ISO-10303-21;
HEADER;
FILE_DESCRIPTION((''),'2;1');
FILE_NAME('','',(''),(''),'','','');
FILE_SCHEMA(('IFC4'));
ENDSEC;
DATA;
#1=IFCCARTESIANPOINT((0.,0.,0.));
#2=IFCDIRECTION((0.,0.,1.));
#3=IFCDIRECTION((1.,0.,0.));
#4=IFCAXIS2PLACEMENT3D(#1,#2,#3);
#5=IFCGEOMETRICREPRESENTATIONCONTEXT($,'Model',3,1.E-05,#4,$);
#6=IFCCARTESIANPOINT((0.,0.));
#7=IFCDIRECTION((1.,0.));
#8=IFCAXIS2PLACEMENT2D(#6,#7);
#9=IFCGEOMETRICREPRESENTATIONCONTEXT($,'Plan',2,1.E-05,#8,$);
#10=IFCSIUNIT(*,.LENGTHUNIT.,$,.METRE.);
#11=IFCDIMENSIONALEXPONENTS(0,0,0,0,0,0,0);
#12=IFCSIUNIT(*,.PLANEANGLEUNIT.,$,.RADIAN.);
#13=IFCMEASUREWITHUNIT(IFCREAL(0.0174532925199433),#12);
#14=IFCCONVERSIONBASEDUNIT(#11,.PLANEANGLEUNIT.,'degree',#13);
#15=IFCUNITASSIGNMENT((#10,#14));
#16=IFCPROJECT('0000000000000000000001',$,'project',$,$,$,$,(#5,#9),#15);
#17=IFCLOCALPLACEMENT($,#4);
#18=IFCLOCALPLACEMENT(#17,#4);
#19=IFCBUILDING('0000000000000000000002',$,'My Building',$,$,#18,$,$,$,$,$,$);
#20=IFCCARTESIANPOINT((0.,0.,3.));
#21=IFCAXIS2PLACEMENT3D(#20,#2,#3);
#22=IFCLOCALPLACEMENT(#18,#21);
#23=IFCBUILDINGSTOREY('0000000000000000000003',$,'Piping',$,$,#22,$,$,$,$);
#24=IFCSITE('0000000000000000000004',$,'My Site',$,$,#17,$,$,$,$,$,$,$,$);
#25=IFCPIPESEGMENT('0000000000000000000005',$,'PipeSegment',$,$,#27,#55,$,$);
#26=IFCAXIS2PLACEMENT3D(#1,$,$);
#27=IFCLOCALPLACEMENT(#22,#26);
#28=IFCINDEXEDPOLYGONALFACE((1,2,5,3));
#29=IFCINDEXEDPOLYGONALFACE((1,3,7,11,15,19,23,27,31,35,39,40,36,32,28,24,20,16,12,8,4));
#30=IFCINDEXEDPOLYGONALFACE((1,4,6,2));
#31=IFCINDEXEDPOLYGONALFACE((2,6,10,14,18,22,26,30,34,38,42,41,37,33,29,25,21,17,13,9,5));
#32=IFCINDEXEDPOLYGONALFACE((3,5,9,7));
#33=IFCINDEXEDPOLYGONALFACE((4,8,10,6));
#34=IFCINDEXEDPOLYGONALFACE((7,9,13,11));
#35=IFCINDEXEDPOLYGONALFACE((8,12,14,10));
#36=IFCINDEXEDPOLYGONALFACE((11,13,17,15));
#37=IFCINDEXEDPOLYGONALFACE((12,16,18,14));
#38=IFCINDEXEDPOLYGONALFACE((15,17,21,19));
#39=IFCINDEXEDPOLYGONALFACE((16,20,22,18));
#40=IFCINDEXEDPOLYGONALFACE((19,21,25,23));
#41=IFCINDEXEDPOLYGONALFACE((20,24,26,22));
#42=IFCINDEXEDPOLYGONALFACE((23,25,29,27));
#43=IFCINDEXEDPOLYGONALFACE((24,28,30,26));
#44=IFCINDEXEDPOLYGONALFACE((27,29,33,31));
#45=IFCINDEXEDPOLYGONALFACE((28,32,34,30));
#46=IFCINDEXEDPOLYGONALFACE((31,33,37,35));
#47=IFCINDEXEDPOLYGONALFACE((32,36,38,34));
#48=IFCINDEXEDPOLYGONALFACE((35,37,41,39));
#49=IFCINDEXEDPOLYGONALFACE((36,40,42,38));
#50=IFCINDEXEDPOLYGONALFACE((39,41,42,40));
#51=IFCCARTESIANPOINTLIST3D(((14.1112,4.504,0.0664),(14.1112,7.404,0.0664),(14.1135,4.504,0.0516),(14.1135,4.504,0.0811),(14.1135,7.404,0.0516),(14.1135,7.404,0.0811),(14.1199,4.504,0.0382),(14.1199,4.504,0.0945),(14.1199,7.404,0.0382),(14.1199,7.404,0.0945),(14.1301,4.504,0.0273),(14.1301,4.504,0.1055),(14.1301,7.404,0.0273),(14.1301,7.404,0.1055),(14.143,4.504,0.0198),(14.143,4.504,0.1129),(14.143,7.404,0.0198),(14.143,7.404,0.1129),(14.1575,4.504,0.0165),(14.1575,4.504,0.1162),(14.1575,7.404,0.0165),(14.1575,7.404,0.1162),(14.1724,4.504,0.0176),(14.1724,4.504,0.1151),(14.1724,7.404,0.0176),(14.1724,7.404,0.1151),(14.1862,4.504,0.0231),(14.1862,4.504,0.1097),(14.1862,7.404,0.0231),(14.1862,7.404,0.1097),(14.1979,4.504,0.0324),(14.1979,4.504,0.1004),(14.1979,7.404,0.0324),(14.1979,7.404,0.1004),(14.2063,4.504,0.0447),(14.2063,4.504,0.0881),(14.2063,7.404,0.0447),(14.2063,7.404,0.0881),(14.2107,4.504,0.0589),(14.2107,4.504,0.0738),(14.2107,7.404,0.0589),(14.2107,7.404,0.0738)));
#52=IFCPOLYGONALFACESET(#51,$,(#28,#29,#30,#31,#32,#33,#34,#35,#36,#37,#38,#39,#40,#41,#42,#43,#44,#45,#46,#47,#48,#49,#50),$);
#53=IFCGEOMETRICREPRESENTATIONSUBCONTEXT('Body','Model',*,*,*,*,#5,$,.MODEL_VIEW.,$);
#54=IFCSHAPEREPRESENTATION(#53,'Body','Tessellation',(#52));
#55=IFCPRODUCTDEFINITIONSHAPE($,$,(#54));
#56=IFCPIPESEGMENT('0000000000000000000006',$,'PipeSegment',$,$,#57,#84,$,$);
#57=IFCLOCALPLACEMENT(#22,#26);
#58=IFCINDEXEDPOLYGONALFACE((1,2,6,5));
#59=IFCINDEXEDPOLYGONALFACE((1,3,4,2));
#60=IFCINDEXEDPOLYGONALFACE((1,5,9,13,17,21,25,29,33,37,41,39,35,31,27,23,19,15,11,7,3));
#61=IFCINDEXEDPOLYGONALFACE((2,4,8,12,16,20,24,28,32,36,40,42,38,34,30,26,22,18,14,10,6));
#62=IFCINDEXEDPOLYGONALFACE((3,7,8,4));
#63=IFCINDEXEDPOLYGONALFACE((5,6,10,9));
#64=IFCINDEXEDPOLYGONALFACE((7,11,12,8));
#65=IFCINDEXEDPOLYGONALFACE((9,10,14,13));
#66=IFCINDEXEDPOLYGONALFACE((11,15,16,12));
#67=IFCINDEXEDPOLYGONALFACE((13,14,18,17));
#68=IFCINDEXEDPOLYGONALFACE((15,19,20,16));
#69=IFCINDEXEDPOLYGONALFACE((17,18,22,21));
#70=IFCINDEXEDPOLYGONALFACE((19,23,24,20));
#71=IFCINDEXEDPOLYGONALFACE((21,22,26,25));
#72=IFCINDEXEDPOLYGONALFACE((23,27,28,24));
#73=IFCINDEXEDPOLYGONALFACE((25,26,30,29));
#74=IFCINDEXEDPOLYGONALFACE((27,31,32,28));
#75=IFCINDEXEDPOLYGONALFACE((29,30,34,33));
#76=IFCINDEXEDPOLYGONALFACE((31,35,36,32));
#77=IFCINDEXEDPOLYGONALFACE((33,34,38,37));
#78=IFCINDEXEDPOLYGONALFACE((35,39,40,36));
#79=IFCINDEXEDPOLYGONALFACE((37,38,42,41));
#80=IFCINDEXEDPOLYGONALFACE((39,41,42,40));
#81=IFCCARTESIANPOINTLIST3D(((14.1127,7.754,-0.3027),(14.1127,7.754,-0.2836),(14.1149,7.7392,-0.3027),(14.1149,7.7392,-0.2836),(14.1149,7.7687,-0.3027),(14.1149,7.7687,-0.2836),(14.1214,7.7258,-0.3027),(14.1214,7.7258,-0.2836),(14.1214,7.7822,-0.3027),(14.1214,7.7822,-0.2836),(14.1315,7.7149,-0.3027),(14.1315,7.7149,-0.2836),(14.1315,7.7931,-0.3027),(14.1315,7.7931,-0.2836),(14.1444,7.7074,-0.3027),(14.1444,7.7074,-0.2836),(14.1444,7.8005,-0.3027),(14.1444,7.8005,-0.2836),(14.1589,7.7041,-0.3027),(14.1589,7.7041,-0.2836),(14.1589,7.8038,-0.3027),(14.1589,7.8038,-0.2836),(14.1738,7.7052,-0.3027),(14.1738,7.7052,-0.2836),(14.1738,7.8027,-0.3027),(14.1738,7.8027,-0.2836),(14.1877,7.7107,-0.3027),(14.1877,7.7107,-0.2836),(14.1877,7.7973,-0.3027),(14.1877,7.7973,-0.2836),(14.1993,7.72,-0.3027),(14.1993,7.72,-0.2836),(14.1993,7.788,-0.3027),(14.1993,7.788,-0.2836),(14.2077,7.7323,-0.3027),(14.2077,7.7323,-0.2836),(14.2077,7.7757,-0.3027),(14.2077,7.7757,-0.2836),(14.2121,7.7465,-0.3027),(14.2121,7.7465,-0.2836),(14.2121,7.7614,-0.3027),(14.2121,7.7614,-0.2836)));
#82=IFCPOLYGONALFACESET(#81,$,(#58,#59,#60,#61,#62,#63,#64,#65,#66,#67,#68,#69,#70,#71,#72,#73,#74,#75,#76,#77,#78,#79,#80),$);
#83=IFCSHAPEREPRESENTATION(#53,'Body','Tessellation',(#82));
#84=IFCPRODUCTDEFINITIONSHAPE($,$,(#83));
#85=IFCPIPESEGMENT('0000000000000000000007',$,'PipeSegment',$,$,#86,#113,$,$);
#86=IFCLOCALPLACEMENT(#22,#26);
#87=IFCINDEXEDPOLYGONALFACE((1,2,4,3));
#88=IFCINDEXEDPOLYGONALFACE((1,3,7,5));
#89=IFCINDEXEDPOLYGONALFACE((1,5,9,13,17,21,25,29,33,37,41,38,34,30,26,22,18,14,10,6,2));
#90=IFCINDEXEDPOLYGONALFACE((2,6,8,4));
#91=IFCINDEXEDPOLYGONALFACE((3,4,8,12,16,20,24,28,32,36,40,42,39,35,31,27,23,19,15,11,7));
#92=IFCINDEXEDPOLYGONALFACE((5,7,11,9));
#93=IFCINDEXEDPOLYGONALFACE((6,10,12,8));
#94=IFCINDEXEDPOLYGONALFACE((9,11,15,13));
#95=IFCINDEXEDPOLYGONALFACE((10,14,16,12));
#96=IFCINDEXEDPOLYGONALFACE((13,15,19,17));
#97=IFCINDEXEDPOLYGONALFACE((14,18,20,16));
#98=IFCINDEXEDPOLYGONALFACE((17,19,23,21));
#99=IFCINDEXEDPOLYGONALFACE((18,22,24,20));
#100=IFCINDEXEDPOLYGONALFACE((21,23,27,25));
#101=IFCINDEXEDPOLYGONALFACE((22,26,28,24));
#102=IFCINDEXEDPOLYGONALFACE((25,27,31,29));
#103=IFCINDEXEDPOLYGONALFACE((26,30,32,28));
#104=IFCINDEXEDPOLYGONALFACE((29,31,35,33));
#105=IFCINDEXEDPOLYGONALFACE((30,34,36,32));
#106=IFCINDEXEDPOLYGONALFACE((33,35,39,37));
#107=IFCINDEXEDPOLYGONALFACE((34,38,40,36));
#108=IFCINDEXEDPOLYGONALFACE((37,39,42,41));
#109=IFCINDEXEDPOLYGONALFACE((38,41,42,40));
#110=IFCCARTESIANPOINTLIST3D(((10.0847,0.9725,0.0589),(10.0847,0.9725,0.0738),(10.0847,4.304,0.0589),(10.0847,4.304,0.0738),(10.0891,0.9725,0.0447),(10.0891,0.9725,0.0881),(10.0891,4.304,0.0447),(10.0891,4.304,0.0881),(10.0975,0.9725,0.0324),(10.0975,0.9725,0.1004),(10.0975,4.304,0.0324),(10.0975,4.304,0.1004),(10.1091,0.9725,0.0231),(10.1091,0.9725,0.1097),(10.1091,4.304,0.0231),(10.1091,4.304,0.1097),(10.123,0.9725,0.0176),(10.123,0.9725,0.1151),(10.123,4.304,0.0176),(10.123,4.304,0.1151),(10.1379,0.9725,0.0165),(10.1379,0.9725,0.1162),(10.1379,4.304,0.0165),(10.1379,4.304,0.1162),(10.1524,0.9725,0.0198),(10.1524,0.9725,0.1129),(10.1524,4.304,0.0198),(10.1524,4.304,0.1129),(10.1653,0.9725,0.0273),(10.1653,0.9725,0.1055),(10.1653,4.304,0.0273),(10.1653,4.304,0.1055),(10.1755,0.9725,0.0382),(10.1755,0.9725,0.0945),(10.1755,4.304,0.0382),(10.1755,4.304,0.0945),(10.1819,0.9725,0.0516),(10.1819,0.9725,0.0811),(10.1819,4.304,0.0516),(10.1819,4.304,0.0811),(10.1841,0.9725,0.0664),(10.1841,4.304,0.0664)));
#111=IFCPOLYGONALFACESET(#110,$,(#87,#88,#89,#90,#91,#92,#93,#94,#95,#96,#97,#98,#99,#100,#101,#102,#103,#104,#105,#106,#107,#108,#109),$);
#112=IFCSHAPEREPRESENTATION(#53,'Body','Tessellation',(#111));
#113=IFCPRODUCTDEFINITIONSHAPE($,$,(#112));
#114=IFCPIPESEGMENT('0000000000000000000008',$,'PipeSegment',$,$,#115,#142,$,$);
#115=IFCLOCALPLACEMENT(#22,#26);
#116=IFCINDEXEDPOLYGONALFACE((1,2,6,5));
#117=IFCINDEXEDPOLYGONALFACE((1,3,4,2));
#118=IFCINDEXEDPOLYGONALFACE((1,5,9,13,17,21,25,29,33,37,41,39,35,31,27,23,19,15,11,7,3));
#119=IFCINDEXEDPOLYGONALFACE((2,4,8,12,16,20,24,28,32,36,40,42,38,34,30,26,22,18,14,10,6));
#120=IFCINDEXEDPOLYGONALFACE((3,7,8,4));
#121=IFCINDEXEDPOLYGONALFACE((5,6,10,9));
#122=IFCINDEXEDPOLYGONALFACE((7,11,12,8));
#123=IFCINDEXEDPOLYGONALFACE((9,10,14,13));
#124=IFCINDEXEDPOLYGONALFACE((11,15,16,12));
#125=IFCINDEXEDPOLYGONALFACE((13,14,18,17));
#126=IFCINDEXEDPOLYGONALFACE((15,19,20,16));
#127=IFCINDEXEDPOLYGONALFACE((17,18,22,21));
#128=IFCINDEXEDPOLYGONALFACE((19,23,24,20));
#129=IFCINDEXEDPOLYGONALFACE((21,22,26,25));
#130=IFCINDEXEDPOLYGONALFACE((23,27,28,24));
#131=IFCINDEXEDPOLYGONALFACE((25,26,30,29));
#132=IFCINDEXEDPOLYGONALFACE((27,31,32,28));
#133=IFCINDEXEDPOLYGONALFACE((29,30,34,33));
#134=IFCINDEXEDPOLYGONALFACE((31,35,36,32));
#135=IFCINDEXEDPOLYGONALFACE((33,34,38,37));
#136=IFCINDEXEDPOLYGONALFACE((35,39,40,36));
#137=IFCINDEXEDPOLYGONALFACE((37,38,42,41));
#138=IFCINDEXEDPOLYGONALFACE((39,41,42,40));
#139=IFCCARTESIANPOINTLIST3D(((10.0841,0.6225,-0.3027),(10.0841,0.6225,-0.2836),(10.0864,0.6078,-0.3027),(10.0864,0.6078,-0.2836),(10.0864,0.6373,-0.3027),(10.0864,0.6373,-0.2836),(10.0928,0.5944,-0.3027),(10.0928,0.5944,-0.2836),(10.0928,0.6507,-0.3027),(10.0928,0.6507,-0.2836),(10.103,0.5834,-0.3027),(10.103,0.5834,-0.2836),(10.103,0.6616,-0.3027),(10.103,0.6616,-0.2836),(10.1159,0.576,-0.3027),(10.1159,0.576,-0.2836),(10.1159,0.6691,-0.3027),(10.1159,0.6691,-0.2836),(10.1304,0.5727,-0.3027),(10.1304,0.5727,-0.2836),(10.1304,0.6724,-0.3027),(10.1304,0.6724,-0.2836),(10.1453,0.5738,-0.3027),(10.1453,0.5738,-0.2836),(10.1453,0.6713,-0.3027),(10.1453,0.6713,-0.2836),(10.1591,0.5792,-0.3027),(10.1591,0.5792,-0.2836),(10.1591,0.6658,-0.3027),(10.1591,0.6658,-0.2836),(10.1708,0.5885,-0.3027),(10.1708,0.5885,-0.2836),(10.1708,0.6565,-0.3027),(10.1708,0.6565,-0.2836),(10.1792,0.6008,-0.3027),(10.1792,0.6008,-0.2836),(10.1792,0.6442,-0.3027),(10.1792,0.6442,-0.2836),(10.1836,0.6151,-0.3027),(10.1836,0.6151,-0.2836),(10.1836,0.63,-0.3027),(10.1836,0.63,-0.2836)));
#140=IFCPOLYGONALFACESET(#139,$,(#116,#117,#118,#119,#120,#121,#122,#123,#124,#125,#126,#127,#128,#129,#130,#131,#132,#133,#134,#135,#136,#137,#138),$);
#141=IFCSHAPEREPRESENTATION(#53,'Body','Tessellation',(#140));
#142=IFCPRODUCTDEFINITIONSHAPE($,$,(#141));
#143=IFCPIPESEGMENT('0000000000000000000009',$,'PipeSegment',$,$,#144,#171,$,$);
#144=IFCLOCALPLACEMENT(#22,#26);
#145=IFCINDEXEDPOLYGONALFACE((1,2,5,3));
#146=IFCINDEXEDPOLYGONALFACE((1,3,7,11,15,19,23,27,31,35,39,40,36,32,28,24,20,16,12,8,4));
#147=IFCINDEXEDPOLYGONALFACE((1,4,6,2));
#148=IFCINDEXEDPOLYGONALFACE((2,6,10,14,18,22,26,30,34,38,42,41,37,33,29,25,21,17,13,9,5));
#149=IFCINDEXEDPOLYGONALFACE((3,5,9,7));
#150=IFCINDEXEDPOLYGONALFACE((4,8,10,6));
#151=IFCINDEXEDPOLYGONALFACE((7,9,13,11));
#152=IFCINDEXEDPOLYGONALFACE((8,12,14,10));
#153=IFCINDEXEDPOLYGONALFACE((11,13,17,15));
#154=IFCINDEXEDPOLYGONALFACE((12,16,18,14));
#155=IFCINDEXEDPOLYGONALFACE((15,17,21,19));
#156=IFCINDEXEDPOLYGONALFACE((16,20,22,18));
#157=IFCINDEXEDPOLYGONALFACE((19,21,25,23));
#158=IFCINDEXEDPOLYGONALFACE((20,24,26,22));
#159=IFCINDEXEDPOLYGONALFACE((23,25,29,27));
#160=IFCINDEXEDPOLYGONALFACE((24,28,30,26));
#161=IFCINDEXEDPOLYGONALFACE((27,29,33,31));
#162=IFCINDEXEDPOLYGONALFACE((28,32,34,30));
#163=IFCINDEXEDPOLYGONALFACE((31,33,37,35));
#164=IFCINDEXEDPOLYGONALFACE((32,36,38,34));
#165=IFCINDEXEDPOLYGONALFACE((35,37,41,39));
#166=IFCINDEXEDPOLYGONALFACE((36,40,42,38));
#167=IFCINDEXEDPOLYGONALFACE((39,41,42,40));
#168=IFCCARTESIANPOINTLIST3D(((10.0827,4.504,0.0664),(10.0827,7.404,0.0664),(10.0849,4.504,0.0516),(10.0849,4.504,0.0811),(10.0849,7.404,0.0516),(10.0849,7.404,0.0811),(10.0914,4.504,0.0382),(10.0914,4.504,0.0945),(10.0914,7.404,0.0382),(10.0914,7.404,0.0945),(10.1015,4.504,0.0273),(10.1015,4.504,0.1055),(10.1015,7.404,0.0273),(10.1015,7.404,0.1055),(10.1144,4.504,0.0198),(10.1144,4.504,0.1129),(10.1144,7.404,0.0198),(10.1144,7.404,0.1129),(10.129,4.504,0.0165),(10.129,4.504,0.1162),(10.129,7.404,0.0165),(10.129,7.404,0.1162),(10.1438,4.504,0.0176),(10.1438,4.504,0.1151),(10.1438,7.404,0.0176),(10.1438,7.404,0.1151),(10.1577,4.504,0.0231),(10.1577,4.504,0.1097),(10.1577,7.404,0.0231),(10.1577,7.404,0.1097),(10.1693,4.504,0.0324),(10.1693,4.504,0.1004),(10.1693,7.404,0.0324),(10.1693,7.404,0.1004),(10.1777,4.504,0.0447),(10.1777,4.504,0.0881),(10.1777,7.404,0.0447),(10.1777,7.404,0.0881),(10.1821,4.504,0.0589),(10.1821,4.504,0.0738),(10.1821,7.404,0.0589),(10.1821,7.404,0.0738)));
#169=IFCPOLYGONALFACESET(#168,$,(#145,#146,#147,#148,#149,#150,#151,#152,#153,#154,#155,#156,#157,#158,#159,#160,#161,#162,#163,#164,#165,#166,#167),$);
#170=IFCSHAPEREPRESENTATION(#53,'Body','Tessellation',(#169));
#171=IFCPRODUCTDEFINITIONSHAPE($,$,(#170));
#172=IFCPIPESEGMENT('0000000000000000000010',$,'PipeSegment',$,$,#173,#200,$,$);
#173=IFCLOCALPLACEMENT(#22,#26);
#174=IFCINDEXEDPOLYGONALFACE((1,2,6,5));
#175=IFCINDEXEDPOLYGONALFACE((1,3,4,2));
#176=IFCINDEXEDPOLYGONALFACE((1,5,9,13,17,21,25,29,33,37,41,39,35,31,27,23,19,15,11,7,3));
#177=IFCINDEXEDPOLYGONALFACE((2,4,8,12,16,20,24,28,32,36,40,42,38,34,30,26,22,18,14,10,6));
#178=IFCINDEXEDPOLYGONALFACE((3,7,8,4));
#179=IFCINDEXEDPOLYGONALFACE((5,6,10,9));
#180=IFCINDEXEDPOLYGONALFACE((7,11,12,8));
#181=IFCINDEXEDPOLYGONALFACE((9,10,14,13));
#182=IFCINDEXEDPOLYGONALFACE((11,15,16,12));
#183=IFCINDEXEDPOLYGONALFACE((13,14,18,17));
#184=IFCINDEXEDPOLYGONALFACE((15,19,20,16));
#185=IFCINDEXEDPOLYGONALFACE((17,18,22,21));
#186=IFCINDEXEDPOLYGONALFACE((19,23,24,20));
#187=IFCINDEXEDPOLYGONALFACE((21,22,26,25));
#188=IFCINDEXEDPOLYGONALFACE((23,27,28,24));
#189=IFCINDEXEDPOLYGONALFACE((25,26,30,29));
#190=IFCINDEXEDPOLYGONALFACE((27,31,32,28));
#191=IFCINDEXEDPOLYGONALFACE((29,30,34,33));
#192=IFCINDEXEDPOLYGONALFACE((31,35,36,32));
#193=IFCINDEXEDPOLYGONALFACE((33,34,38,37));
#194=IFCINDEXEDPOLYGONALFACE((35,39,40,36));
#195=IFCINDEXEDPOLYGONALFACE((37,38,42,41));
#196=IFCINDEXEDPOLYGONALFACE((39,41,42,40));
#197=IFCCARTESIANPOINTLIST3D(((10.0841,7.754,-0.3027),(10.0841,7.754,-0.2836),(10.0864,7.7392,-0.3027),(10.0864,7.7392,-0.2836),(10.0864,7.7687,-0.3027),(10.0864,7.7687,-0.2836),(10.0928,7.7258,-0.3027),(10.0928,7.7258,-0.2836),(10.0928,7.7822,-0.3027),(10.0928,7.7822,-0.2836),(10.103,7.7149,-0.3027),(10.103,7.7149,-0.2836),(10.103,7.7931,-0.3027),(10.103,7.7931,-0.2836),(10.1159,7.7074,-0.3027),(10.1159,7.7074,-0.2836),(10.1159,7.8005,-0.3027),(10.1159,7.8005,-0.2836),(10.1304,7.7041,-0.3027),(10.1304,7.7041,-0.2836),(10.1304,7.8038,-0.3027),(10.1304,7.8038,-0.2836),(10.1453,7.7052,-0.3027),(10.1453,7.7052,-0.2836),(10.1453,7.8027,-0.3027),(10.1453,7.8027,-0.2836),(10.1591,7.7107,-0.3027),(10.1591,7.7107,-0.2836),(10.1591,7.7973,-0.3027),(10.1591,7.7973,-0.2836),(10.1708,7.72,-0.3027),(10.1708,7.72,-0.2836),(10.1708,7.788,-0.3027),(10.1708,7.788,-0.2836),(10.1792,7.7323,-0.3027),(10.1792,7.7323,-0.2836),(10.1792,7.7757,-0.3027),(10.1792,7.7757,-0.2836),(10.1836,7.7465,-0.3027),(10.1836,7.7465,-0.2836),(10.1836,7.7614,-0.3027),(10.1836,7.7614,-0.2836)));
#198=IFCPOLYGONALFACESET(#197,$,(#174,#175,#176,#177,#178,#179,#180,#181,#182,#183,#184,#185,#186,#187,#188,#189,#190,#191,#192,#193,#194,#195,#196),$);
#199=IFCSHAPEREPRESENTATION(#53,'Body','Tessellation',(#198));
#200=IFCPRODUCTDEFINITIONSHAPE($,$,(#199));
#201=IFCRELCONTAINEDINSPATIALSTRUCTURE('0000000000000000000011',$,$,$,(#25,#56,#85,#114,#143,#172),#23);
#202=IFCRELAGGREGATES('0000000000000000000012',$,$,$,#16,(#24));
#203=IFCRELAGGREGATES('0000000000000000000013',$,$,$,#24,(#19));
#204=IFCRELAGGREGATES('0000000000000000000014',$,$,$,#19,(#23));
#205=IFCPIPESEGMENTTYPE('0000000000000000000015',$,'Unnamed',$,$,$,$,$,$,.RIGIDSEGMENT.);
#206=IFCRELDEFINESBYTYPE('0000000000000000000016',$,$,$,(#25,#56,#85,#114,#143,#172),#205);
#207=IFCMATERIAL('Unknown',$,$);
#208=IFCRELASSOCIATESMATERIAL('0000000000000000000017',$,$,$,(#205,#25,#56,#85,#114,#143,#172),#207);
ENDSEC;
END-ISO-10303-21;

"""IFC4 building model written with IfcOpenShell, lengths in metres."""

from ifc_helpers import new_model, entity, si_unit, converted_unit, frame, origin_with_axes, origin_2d_with_axis, place, context, subcontext, project, spatial, circle, extrude, material, material_profile, profile_set, profile_usage, type_object, element, save


model = new_model("IFC4")

# Units and contexts
model_context = context("Model", 3, precision=1e-05, world=origin_with_axes())
plan_context = context("Plan", 2, precision=1e-05, world=origin_2d_with_axis())
body_context = subcontext(model_context, "Body", "Model", "MODEL_VIEW")
ifc_project = project(units=[si_unit("LENGTHUNIT", "METRE"), converted_unit("PLANEANGLEUNIT", "degree", entity("IfcReal", 0.0174532925199433), si_unit("PLANEANGLEUNIT", "RADIAN"), dimensions=[0, 0, 0, 0, 0, 0, 0])], contexts=[model_context, plan_context])

# Site, building, storey
site_placement = place(None, origin_with_axes())
site = spatial("IfcSite", under=ifc_project, at=site_placement, Name="My Site")
building_placement = place(site_placement, origin_with_axes())
building = spatial("IfcBuilding", under=site, at=building_placement, Name="My Building")
storey_placement = place(building_placement, frame((0.0, 0.0, 3.0), z_axis=(0.0, 0.0, 1.0), x_axis=(1.0, 0.0, 0.0)))
storey = spatial("IfcBuildingStorey", under=building, at=storey_placement, Name="Piping")

# Pipe segments
ifc_material = material(Name="Unknown")
ifc_material_profile_1 = material_profile(ifc_material, circle(Radius=0.05))
ifc_profile_set_1 = profile_set([ifc_material_profile_1])
pipe_segment_type = type_object("IfcPipeSegmentType", Name="Unnamed", PredefinedType="RIGIDSEGMENT", material=ifc_profile_set_1)
ifc_profile_usage_1 = profile_usage(ifc_profile_set_1, cardinal=5)
pipe_segment_1_placement = place(storey_placement, frame((14.1612, 4.504, 0.0664), z_axis=(0.0, 1.0, 0.0), x_axis=(-1.0, 0.0, 0.0)))
element("IfcPipeSegment", 1, at=pipe_segment_1_placement, inside=storey, type_object=pipe_segment_type, material=ifc_profile_usage_1, Name="PipeSegment", context=body_context, shape_type="SweptSolid", body=[
    extrude(circle(Radius=0.05), origin_with_axes(), (0.0, 0.0, 1.0), 2.9),
])
ifc_profile_usage_2 = profile_usage(ifc_profile_set_1, cardinal=5)
pipe_segment_2_placement = place(storey_placement, frame((14.1627, 7.754, -0.2836), z_axis=(0.0, 0.0, -1.0), x_axis=(-1.0, 0.0, 0.0)))
element("IfcPipeSegment", 2, at=pipe_segment_2_placement, inside=storey, type_object=pipe_segment_type, material=ifc_profile_usage_2, Name="PipeSegment", context=body_context, shape_type="SweptSolid", body=[
    extrude(circle(Radius=0.05), origin_with_axes(), (0.0, 0.0, 1.0), 0.0191),
])
ifc_profile_usage_3 = profile_usage(ifc_profile_set_1, cardinal=5)
pipe_segment_3_placement = place(storey_placement, frame((10.1341, 4.304, 0.0664), z_axis=(0.0, -1.0, 0.000002), x_axis=(1.0, 0.0, 0.0)))
element("IfcPipeSegment", 3, at=pipe_segment_3_placement, inside=storey, type_object=pipe_segment_type, material=ifc_profile_usage_3, Name="PipeSegment", context=body_context, shape_type="SweptSolid", body=[
    extrude(circle(Radius=0.05), origin_with_axes(), (0.0, 0.0, 1.0), 3.3315),
])
ifc_profile_usage_4 = profile_usage(ifc_profile_set_1, cardinal=5)
pipe_segment_4_placement = place(storey_placement, frame((10.1341, 0.6225, -0.2836), z_axis=(0.0, 0.0, -1.0), x_axis=(-1.0, 0.0, 0.0)))
element("IfcPipeSegment", 4, at=pipe_segment_4_placement, inside=storey, type_object=pipe_segment_type, material=ifc_profile_usage_4, Name="PipeSegment", context=body_context, shape_type="SweptSolid", body=[
    extrude(circle(Radius=0.05), origin_with_axes(), (0.0, 0.0, 1.0), 0.0191),
])
ifc_profile_usage_5 = profile_usage(ifc_profile_set_1, cardinal=5)
pipe_segment_5_placement = place(storey_placement, frame((10.1327, 4.504, 0.0664), z_axis=(0.0, 1.0, 0.0), x_axis=(-1.0, 0.0, 0.0)))
element("IfcPipeSegment", 5, at=pipe_segment_5_placement, inside=storey, type_object=pipe_segment_type, material=ifc_profile_usage_5, Name="PipeSegment", context=body_context, shape_type="SweptSolid", body=[
    extrude(circle(Radius=0.05), origin_with_axes(), (0.0, 0.0, 1.0), 2.9),
])
ifc_profile_usage_6 = profile_usage(ifc_profile_set_1, cardinal=5)
pipe_segment_6_placement = place(storey_placement, frame((10.1341, 7.754, -0.2836), z_axis=(0.0, 0.0, -1.0), x_axis=(-1.0, 0.0, 0.0)))
element("IfcPipeSegment", 6, at=pipe_segment_6_placement, inside=storey, type_object=pipe_segment_type, material=ifc_profile_usage_6, Name="PipeSegment", context=body_context, shape_type="SweptSolid", body=[
    extrude(circle(Radius=0.05), origin_with_axes(), (0.0, 0.0, 1.0), 0.0191),
])

save(model, "model.ifc")
